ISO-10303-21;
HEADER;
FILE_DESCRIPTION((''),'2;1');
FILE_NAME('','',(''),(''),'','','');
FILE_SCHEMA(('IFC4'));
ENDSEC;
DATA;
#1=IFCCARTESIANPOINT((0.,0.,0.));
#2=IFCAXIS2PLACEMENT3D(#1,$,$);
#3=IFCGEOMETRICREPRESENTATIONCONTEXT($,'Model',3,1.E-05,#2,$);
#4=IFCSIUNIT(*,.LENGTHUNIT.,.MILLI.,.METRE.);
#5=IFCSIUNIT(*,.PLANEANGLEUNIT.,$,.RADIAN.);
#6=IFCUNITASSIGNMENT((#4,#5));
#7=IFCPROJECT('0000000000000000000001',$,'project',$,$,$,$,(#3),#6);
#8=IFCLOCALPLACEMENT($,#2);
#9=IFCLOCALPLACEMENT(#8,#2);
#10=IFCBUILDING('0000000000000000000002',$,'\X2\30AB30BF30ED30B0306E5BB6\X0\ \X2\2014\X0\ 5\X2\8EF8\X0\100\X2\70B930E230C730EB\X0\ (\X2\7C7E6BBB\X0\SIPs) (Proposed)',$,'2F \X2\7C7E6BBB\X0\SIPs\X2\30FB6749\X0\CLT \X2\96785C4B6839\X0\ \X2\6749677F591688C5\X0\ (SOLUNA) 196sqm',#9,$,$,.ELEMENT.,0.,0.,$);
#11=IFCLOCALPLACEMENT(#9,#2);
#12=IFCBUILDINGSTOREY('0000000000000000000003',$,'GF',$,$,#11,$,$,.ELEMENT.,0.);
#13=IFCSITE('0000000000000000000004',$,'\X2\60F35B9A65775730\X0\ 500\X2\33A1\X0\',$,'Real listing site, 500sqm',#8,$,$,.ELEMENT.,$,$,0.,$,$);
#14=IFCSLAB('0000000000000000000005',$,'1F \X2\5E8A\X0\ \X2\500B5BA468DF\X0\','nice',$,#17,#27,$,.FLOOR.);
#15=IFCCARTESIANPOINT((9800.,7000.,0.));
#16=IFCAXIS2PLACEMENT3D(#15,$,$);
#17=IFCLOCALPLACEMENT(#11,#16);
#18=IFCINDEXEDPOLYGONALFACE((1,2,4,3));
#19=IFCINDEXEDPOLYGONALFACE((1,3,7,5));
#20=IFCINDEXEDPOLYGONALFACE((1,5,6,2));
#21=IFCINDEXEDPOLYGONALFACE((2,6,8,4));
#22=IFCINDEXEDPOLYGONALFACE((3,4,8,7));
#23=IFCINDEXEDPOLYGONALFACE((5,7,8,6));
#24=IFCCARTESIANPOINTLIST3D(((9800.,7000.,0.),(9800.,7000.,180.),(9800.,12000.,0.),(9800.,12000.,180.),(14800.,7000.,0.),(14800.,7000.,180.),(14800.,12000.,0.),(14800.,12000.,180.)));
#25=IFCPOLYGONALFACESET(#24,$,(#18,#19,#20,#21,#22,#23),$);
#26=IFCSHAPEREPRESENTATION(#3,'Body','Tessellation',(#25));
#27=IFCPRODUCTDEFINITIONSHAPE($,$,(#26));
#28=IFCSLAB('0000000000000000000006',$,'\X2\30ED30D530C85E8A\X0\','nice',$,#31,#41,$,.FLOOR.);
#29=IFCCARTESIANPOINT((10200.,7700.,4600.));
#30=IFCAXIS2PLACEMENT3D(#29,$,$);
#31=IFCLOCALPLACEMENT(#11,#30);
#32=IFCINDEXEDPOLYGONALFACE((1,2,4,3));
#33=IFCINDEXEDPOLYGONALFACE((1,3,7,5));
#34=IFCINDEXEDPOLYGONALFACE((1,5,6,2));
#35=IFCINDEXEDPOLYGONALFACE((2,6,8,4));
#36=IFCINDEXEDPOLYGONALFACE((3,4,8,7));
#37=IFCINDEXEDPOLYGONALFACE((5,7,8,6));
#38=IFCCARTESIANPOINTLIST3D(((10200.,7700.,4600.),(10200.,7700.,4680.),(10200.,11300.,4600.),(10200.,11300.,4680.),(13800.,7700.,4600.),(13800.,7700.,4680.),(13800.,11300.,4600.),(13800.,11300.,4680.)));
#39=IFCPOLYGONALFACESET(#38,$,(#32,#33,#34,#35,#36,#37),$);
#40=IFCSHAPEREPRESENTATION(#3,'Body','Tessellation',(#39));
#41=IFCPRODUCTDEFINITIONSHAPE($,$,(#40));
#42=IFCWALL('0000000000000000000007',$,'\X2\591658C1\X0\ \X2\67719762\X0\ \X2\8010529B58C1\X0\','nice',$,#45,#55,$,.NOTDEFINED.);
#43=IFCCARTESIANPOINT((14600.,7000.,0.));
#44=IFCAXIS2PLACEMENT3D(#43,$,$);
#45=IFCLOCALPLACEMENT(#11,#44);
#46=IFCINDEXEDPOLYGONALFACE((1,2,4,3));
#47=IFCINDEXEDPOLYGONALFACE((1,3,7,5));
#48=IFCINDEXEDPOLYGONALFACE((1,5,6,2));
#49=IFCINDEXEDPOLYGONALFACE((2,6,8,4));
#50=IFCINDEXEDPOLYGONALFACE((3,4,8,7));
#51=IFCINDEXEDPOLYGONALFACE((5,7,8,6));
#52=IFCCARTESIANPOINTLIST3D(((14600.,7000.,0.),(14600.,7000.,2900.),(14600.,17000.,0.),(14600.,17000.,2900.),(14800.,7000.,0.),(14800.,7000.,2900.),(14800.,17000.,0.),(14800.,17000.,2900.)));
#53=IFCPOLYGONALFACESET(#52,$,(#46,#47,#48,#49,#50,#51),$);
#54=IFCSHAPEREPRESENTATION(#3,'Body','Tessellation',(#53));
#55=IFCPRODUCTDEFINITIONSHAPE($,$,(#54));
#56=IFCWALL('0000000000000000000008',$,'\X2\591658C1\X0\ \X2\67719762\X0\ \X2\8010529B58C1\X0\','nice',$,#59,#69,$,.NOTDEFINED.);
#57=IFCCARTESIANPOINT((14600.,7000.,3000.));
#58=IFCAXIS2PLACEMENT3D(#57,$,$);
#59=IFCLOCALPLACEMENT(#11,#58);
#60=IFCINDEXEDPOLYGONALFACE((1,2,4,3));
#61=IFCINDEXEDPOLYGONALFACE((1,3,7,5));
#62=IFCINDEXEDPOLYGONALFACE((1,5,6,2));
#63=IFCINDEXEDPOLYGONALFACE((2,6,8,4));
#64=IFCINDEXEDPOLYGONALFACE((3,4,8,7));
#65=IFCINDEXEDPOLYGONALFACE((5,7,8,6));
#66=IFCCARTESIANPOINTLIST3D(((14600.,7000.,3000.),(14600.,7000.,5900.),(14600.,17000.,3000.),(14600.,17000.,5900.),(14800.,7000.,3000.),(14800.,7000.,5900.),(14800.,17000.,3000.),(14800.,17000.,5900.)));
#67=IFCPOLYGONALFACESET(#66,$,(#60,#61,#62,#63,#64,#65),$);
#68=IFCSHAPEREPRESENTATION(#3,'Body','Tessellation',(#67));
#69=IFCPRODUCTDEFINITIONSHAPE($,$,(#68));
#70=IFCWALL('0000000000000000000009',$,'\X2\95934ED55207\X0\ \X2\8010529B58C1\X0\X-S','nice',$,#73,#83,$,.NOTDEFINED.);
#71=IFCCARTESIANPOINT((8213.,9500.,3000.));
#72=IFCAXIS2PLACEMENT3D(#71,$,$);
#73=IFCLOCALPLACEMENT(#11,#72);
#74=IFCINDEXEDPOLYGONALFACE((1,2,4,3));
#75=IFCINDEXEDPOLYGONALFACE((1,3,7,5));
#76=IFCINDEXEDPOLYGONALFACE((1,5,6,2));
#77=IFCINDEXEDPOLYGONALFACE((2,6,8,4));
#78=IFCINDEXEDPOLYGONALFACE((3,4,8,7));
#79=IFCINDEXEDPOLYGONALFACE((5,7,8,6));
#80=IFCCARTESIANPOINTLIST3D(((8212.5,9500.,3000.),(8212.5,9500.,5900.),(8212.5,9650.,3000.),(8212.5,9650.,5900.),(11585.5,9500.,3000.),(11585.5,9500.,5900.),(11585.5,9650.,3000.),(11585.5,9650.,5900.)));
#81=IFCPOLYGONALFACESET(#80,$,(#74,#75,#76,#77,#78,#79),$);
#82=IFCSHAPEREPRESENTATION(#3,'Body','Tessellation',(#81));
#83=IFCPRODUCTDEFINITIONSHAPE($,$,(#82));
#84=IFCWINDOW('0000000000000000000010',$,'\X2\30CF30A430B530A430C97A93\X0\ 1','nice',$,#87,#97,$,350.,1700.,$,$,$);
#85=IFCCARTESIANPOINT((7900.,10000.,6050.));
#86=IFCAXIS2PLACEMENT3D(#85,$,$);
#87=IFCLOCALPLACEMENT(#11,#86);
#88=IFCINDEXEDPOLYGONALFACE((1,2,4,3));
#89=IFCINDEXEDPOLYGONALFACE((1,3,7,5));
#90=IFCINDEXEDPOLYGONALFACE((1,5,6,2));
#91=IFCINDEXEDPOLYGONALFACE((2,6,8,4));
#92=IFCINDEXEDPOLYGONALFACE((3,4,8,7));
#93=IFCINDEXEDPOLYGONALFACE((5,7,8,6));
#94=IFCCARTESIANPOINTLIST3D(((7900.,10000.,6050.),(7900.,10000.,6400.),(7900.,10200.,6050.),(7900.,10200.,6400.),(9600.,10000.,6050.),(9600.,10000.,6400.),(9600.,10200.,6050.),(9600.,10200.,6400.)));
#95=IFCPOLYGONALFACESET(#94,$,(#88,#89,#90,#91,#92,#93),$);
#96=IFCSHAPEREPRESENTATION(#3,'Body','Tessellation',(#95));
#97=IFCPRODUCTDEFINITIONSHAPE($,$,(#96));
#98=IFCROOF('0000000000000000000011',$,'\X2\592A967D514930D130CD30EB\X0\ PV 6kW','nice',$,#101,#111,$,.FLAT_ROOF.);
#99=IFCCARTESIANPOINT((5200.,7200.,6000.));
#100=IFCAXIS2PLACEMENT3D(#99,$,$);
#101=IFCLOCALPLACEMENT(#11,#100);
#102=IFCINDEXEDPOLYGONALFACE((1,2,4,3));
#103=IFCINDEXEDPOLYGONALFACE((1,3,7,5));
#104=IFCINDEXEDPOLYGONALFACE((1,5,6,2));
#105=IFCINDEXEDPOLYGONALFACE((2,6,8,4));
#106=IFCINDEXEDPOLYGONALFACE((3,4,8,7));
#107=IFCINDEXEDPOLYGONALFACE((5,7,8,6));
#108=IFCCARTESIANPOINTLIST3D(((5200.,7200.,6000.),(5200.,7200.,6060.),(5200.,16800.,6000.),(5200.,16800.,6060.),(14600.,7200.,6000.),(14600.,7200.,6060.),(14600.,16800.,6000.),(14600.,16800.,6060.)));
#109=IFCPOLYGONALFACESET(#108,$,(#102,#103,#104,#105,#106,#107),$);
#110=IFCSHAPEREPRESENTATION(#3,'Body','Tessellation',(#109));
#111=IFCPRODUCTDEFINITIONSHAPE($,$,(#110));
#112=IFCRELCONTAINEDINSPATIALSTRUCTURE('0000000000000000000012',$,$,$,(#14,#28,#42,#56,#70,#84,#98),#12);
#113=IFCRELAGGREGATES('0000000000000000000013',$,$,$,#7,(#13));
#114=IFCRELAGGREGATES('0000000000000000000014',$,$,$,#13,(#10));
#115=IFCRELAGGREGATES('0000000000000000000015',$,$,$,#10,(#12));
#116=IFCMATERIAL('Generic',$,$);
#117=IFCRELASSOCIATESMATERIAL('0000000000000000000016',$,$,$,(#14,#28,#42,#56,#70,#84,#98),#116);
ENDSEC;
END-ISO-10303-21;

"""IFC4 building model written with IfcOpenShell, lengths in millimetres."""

from ifc_helpers import new_model, si_unit, frame, frame_2d, origin, place, context, project, spatial, rectangle, extrude, material, element, save


model = new_model("IFC4")

# Units and contexts
model_context = context("Model", 3, precision=1e-05, world=origin())
ifc_project = project(units=[si_unit("LENGTHUNIT", "METRE", prefix="MILLI"), si_unit("PLANEANGLEUNIT", "RADIAN")], contexts=[model_context])

# Site, building, storey
site_placement = place(None, origin())
site = spatial("IfcSite", under=ifc_project, at=site_placement, Name="想定敷地 500㎡", ObjectType="Real listing site, 500sqm", CompositionType="ELEMENT", RefElevation=0.0)
building_placement = place(site_placement, origin())
building = spatial("IfcBuilding", under=site, at=building_placement, Name="カタログの家 — 5軸100点モデル (籾殻SIPs) (Proposed)", ObjectType="2F 籾殻SIPs・杉CLT 陸屋根 杉板外装 (SOLUNA) 196sqm", CompositionType="ELEMENT", ElevationOfRefHeight=0.0, ElevationOfTerrain=0.0)
storey_placement = place(building_placement, origin())
storey = spatial("IfcBuildingStorey", under=building, at=storey_placement, Name="GF", CompositionType="ELEMENT", Elevation=0.0)

# Slabs
ifc_material = material(Name="Generic")
slab_1_placement = place(storey_placement, frame((9800.0, 7000.0, 0.0)))
element("IfcSlab", 1, at=slab_1_placement, inside=storey, material=ifc_material, Name="1F 床 個室棟", Description="nice", PredefinedType="FLOOR", context=model_context, shape_type="SweptSolid", body=[
    extrude(rectangle(XDim=5000.0, YDim=5000.0, at=frame_2d((2500.0, 2500.0))), frame((9800.0, 7000.0, 0.0)), (0.0, 0.0, 1.0), 180.0),
])
slab_2_placement = place(storey_placement, frame((10200.0, 7700.0, 4600.0)))
element("IfcSlab", 2, at=slab_2_placement, inside=storey, material=ifc_material, Name="ロフト床", Description="nice", PredefinedType="FLOOR", context=model_context, shape_type="SweptSolid", body=[
    extrude(rectangle(XDim=3600.0, YDim=3600.0, at=frame_2d((1800.0, 1800.0))), frame((10200.0, 7700.0, 4600.0)), (0.0, 0.0, 1.0), 80.0),
])

# Walls
wall_1_placement = place(storey_placement, frame((14600.0, 7000.0, 0.0)))
element("IfcWall", 3, at=wall_1_placement, inside=storey, material=ifc_material, Name="外壁 東面 耐力壁", Description="nice", PredefinedType="NOTDEFINED", context=model_context, shape_type="SweptSolid", body=[
    extrude(rectangle(XDim=200.0, YDim=10000.0, at=frame_2d((100.0, 5000.0))), frame((14600.0, 7000.0, 0.0)), (0.0, 0.0, 1.0), 2900.0),
])
wall_2_placement = place(storey_placement, frame((14600.0, 7000.0, 3000.0)))
element("IfcWall", 4, at=wall_2_placement, inside=storey, material=ifc_material, Name="外壁 東面 耐力壁", Description="nice", PredefinedType="NOTDEFINED", context=model_context, shape_type="SweptSolid", body=[
    extrude(rectangle(XDim=200.0, YDim=10000.0, at=frame_2d((100.0, 5000.0))), frame((14600.0, 7000.0, 3000.0)), (0.0, 0.0, 1.0), 2900.0),
])
wall_3_placement = place(storey_placement, frame((8213.0, 9500.0, 3000.0)))
element("IfcWall", 5, at=wall_3_placement, inside=storey, material=ifc_material, Name="間仕切 耐力壁X-S", Description="nice", PredefinedType="NOTDEFINED", context=model_context, shape_type="SweptSolid", body=[
    extrude(rectangle(XDim=3373.0, YDim=150.0, at=frame_2d((1686.0, 75.0))), frame((8213.0, 9500.0, 3000.0)), (0.0, 0.0, 1.0), 2900.0),
])

# Window
window_placement = place(storey_placement, frame((7900.0, 10000.0, 6050.0)))
element("IfcWindow", 6, at=window_placement, inside=storey, material=ifc_material, Name="ハイサイド窓 1", Description="nice", OverallHeight=350.0, OverallWidth=1700.0, context=model_context, shape_type="SweptSolid", body=[
    extrude(rectangle(XDim=1700.0, YDim=200.0, at=frame_2d((850.0, 100.0))), frame((7900.0, 10000.0, 6050.0)), (0.0, 0.0, 1.0), 350.0),
])

# Roof
roof_placement = place(storey_placement, frame((5200.0, 7200.0, 6000.0)))
element("IfcRoof", 7, at=roof_placement, inside=storey, material=ifc_material, Name="太陽光パネル PV 6kW", Description="nice", PredefinedType="FLAT_ROOF", context=model_context, shape_type="SweptSolid", body=[
    extrude(rectangle(XDim=9400.0, YDim=9600.0, at=frame_2d((4700.0, 4800.0))), frame((5200.0, 7200.0, 6000.0)), (0.0, 0.0, 1.0), 60.0),
])

save(model, "model.ifc")
